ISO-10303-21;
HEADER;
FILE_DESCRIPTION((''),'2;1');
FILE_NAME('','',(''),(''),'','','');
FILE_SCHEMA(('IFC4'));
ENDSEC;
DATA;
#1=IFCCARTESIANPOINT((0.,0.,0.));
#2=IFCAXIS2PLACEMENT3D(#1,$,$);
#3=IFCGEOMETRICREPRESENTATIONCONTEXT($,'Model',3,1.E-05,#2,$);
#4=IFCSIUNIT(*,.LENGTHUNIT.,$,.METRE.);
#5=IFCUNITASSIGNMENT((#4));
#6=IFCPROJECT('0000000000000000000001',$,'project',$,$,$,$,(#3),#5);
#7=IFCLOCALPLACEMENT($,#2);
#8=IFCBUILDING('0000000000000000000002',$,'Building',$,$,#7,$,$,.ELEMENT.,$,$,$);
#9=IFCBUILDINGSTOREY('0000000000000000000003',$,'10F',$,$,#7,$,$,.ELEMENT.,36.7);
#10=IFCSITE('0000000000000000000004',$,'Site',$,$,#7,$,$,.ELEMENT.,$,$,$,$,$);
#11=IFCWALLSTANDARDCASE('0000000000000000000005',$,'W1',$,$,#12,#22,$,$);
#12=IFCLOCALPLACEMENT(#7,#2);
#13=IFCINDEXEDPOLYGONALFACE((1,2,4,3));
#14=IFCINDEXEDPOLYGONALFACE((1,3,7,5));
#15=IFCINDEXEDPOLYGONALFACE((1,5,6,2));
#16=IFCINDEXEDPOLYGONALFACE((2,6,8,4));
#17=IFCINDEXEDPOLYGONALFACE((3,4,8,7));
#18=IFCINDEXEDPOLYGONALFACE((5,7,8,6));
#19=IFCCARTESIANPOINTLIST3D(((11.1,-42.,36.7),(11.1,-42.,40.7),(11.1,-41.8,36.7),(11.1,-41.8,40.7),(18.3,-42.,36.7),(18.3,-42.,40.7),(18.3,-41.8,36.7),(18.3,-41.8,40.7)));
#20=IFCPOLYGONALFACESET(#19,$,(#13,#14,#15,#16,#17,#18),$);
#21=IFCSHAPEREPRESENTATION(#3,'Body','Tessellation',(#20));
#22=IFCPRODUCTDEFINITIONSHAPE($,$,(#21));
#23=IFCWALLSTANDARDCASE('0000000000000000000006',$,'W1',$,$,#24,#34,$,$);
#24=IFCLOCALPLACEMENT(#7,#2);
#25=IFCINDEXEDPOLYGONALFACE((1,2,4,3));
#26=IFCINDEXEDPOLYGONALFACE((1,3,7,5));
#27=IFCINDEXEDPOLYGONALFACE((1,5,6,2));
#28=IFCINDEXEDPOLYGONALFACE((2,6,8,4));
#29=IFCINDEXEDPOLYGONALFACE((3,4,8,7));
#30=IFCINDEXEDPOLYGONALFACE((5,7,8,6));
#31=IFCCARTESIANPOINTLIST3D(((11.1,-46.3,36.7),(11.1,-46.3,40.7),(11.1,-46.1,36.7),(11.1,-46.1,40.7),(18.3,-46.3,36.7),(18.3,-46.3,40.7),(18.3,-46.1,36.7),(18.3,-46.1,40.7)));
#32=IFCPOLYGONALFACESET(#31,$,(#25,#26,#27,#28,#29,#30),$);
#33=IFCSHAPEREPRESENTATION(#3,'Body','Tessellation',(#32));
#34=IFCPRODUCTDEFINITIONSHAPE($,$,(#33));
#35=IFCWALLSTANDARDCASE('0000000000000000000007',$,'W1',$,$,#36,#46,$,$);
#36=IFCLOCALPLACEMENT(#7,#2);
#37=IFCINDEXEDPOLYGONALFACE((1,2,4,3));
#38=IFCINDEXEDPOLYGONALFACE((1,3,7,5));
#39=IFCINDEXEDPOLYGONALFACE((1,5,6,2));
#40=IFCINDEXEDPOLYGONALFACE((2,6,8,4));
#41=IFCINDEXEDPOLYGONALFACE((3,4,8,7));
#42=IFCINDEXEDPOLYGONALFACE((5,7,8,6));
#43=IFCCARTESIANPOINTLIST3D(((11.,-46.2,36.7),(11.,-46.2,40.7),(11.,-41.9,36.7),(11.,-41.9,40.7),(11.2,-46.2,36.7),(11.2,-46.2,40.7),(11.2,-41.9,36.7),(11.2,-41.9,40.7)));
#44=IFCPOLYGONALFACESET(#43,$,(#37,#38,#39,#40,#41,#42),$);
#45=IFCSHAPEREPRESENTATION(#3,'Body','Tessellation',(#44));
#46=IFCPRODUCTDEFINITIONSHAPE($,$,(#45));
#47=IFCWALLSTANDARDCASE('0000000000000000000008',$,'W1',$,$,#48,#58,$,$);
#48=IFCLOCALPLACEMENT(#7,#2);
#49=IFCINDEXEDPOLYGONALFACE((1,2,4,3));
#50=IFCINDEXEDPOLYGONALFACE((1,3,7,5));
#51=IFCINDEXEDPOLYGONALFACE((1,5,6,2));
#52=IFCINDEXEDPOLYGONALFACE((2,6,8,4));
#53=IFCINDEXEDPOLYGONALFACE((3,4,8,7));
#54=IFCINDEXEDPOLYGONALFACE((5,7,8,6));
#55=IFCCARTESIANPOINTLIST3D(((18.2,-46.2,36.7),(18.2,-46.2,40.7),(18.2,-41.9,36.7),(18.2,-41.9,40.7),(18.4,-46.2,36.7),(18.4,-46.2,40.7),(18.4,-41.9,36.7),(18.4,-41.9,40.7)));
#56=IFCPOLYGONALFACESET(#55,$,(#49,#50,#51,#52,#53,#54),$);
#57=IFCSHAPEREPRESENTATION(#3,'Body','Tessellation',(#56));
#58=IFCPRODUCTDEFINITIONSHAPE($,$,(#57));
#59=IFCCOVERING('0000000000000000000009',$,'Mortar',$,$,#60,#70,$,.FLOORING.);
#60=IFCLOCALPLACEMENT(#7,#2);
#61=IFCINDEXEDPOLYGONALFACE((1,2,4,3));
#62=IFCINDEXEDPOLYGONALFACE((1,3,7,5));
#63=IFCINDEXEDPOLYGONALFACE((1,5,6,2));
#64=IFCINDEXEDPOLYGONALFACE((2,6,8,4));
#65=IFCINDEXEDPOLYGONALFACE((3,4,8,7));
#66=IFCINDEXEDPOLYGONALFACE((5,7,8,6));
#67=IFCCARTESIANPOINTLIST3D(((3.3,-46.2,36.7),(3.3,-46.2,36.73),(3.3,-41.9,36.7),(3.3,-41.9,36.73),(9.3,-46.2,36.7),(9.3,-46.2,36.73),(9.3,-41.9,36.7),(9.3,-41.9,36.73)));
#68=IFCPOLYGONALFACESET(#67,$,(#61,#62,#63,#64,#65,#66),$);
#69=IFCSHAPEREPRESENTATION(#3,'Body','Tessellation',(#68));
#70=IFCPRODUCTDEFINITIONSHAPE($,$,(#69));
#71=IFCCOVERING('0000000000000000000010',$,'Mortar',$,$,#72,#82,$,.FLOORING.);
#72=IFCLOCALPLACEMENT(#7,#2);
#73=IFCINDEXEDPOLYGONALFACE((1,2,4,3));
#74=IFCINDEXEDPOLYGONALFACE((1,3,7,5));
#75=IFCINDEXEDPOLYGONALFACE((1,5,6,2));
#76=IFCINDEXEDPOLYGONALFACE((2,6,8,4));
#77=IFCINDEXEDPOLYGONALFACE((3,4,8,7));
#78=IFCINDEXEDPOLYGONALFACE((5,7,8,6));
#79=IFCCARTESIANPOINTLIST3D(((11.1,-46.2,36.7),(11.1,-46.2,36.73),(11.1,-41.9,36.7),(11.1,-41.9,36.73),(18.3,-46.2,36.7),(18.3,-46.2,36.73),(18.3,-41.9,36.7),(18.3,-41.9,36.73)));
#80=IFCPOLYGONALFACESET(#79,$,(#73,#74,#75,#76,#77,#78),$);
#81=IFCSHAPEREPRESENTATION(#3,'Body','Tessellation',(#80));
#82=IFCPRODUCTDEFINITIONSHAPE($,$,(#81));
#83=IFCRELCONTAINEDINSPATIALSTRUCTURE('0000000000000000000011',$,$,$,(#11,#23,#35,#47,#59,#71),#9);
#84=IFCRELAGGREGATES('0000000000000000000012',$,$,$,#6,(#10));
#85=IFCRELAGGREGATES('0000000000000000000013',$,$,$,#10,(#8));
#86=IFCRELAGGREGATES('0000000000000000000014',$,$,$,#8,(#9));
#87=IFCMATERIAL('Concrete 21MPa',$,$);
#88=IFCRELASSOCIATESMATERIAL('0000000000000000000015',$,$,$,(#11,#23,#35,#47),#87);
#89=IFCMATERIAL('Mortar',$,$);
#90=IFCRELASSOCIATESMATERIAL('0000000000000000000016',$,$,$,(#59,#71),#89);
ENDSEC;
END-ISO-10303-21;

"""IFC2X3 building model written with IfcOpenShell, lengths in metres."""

from ifc_helpers import new_model, si_unit, frame, origin, origin_2d, place, context, project, spatial, rectangle, extrude, material, element, save


model = new_model("IFC2X3")

# Units and contexts
model_context = context("Model", 3, precision=1e-05, world=origin())
ifc_project = project(units=[si_unit("LENGTHUNIT", "METRE")], contexts=[model_context])

# Site, building, storey
placement = place(None, origin())
site = spatial("IfcSite", under=ifc_project, at=placement, Name="Site", CompositionType="ELEMENT")
building = spatial("IfcBuilding", under=site, at=placement, Name="Building", CompositionType="ELEMENT")
storey = spatial("IfcBuildingStorey", under=building, at=placement, Name="10F", CompositionType="ELEMENT", Elevation=36.7)

# Shared definitions
ifc_material_1 = material(Name="Concrete 21MPa")

# Walls
for number, where, name in (
    (1, (14.7, -41.9, 36.7), "W1"),
    (2, (14.7, -46.2, 36.7), "W1"),
):
    element("IfcWallStandardCase", number, at=place(None, frame(where)), inside=storey, material=ifc_material_1, Name=name, context=model_context, shape_type="SweptSolid", body=[
        extrude(rectangle(XDim=7.2, YDim=0.2, at=origin_2d()), origin(), (0.0, 0.0, 1.0), 4.0),
    ])
for number, where, name in (
    (3, (11.1, -44.05, 36.7), "W1"),
    (4, (18.3, -44.05, 36.7), "W1"),
):
    element("IfcWallStandardCase", number, at=place(None, frame(where)), inside=storey, material=ifc_material_1, Name=name, context=model_context, shape_type="SweptSolid", body=[
        extrude(rectangle(XDim=0.2, YDim=4.3, at=origin_2d()), origin(), (0.0, 0.0, 1.0), 4.0),
    ])

# Coverings
ifc_material_2 = material(Name="Mortar")
covering_1_placement = place(None, frame((6.3, -44.05, 36.7)))
element("IfcCovering", 5, at=covering_1_placement, inside=storey, material=ifc_material_2, Name="Mortar", PredefinedType="FLOORING", context=model_context, shape_type="SweptSolid", body=[
    extrude(rectangle(XDim=6.0, YDim=4.3, at=origin_2d()), origin(), (0.0, 0.0, 1.0), 0.03),
])
covering_2_placement = place(None, frame((14.7, -44.05, 36.7)))
element("IfcCovering", 6, at=covering_2_placement, inside=storey, material=ifc_material_2, Name="Mortar", PredefinedType="FLOORING", context=model_context, shape_type="SweptSolid", body=[
    extrude(rectangle(XDim=7.2, YDim=4.3, at=origin_2d()), origin(), (0.0, 0.0, 1.0), 0.03),
])

save(model, "model.ifc")
